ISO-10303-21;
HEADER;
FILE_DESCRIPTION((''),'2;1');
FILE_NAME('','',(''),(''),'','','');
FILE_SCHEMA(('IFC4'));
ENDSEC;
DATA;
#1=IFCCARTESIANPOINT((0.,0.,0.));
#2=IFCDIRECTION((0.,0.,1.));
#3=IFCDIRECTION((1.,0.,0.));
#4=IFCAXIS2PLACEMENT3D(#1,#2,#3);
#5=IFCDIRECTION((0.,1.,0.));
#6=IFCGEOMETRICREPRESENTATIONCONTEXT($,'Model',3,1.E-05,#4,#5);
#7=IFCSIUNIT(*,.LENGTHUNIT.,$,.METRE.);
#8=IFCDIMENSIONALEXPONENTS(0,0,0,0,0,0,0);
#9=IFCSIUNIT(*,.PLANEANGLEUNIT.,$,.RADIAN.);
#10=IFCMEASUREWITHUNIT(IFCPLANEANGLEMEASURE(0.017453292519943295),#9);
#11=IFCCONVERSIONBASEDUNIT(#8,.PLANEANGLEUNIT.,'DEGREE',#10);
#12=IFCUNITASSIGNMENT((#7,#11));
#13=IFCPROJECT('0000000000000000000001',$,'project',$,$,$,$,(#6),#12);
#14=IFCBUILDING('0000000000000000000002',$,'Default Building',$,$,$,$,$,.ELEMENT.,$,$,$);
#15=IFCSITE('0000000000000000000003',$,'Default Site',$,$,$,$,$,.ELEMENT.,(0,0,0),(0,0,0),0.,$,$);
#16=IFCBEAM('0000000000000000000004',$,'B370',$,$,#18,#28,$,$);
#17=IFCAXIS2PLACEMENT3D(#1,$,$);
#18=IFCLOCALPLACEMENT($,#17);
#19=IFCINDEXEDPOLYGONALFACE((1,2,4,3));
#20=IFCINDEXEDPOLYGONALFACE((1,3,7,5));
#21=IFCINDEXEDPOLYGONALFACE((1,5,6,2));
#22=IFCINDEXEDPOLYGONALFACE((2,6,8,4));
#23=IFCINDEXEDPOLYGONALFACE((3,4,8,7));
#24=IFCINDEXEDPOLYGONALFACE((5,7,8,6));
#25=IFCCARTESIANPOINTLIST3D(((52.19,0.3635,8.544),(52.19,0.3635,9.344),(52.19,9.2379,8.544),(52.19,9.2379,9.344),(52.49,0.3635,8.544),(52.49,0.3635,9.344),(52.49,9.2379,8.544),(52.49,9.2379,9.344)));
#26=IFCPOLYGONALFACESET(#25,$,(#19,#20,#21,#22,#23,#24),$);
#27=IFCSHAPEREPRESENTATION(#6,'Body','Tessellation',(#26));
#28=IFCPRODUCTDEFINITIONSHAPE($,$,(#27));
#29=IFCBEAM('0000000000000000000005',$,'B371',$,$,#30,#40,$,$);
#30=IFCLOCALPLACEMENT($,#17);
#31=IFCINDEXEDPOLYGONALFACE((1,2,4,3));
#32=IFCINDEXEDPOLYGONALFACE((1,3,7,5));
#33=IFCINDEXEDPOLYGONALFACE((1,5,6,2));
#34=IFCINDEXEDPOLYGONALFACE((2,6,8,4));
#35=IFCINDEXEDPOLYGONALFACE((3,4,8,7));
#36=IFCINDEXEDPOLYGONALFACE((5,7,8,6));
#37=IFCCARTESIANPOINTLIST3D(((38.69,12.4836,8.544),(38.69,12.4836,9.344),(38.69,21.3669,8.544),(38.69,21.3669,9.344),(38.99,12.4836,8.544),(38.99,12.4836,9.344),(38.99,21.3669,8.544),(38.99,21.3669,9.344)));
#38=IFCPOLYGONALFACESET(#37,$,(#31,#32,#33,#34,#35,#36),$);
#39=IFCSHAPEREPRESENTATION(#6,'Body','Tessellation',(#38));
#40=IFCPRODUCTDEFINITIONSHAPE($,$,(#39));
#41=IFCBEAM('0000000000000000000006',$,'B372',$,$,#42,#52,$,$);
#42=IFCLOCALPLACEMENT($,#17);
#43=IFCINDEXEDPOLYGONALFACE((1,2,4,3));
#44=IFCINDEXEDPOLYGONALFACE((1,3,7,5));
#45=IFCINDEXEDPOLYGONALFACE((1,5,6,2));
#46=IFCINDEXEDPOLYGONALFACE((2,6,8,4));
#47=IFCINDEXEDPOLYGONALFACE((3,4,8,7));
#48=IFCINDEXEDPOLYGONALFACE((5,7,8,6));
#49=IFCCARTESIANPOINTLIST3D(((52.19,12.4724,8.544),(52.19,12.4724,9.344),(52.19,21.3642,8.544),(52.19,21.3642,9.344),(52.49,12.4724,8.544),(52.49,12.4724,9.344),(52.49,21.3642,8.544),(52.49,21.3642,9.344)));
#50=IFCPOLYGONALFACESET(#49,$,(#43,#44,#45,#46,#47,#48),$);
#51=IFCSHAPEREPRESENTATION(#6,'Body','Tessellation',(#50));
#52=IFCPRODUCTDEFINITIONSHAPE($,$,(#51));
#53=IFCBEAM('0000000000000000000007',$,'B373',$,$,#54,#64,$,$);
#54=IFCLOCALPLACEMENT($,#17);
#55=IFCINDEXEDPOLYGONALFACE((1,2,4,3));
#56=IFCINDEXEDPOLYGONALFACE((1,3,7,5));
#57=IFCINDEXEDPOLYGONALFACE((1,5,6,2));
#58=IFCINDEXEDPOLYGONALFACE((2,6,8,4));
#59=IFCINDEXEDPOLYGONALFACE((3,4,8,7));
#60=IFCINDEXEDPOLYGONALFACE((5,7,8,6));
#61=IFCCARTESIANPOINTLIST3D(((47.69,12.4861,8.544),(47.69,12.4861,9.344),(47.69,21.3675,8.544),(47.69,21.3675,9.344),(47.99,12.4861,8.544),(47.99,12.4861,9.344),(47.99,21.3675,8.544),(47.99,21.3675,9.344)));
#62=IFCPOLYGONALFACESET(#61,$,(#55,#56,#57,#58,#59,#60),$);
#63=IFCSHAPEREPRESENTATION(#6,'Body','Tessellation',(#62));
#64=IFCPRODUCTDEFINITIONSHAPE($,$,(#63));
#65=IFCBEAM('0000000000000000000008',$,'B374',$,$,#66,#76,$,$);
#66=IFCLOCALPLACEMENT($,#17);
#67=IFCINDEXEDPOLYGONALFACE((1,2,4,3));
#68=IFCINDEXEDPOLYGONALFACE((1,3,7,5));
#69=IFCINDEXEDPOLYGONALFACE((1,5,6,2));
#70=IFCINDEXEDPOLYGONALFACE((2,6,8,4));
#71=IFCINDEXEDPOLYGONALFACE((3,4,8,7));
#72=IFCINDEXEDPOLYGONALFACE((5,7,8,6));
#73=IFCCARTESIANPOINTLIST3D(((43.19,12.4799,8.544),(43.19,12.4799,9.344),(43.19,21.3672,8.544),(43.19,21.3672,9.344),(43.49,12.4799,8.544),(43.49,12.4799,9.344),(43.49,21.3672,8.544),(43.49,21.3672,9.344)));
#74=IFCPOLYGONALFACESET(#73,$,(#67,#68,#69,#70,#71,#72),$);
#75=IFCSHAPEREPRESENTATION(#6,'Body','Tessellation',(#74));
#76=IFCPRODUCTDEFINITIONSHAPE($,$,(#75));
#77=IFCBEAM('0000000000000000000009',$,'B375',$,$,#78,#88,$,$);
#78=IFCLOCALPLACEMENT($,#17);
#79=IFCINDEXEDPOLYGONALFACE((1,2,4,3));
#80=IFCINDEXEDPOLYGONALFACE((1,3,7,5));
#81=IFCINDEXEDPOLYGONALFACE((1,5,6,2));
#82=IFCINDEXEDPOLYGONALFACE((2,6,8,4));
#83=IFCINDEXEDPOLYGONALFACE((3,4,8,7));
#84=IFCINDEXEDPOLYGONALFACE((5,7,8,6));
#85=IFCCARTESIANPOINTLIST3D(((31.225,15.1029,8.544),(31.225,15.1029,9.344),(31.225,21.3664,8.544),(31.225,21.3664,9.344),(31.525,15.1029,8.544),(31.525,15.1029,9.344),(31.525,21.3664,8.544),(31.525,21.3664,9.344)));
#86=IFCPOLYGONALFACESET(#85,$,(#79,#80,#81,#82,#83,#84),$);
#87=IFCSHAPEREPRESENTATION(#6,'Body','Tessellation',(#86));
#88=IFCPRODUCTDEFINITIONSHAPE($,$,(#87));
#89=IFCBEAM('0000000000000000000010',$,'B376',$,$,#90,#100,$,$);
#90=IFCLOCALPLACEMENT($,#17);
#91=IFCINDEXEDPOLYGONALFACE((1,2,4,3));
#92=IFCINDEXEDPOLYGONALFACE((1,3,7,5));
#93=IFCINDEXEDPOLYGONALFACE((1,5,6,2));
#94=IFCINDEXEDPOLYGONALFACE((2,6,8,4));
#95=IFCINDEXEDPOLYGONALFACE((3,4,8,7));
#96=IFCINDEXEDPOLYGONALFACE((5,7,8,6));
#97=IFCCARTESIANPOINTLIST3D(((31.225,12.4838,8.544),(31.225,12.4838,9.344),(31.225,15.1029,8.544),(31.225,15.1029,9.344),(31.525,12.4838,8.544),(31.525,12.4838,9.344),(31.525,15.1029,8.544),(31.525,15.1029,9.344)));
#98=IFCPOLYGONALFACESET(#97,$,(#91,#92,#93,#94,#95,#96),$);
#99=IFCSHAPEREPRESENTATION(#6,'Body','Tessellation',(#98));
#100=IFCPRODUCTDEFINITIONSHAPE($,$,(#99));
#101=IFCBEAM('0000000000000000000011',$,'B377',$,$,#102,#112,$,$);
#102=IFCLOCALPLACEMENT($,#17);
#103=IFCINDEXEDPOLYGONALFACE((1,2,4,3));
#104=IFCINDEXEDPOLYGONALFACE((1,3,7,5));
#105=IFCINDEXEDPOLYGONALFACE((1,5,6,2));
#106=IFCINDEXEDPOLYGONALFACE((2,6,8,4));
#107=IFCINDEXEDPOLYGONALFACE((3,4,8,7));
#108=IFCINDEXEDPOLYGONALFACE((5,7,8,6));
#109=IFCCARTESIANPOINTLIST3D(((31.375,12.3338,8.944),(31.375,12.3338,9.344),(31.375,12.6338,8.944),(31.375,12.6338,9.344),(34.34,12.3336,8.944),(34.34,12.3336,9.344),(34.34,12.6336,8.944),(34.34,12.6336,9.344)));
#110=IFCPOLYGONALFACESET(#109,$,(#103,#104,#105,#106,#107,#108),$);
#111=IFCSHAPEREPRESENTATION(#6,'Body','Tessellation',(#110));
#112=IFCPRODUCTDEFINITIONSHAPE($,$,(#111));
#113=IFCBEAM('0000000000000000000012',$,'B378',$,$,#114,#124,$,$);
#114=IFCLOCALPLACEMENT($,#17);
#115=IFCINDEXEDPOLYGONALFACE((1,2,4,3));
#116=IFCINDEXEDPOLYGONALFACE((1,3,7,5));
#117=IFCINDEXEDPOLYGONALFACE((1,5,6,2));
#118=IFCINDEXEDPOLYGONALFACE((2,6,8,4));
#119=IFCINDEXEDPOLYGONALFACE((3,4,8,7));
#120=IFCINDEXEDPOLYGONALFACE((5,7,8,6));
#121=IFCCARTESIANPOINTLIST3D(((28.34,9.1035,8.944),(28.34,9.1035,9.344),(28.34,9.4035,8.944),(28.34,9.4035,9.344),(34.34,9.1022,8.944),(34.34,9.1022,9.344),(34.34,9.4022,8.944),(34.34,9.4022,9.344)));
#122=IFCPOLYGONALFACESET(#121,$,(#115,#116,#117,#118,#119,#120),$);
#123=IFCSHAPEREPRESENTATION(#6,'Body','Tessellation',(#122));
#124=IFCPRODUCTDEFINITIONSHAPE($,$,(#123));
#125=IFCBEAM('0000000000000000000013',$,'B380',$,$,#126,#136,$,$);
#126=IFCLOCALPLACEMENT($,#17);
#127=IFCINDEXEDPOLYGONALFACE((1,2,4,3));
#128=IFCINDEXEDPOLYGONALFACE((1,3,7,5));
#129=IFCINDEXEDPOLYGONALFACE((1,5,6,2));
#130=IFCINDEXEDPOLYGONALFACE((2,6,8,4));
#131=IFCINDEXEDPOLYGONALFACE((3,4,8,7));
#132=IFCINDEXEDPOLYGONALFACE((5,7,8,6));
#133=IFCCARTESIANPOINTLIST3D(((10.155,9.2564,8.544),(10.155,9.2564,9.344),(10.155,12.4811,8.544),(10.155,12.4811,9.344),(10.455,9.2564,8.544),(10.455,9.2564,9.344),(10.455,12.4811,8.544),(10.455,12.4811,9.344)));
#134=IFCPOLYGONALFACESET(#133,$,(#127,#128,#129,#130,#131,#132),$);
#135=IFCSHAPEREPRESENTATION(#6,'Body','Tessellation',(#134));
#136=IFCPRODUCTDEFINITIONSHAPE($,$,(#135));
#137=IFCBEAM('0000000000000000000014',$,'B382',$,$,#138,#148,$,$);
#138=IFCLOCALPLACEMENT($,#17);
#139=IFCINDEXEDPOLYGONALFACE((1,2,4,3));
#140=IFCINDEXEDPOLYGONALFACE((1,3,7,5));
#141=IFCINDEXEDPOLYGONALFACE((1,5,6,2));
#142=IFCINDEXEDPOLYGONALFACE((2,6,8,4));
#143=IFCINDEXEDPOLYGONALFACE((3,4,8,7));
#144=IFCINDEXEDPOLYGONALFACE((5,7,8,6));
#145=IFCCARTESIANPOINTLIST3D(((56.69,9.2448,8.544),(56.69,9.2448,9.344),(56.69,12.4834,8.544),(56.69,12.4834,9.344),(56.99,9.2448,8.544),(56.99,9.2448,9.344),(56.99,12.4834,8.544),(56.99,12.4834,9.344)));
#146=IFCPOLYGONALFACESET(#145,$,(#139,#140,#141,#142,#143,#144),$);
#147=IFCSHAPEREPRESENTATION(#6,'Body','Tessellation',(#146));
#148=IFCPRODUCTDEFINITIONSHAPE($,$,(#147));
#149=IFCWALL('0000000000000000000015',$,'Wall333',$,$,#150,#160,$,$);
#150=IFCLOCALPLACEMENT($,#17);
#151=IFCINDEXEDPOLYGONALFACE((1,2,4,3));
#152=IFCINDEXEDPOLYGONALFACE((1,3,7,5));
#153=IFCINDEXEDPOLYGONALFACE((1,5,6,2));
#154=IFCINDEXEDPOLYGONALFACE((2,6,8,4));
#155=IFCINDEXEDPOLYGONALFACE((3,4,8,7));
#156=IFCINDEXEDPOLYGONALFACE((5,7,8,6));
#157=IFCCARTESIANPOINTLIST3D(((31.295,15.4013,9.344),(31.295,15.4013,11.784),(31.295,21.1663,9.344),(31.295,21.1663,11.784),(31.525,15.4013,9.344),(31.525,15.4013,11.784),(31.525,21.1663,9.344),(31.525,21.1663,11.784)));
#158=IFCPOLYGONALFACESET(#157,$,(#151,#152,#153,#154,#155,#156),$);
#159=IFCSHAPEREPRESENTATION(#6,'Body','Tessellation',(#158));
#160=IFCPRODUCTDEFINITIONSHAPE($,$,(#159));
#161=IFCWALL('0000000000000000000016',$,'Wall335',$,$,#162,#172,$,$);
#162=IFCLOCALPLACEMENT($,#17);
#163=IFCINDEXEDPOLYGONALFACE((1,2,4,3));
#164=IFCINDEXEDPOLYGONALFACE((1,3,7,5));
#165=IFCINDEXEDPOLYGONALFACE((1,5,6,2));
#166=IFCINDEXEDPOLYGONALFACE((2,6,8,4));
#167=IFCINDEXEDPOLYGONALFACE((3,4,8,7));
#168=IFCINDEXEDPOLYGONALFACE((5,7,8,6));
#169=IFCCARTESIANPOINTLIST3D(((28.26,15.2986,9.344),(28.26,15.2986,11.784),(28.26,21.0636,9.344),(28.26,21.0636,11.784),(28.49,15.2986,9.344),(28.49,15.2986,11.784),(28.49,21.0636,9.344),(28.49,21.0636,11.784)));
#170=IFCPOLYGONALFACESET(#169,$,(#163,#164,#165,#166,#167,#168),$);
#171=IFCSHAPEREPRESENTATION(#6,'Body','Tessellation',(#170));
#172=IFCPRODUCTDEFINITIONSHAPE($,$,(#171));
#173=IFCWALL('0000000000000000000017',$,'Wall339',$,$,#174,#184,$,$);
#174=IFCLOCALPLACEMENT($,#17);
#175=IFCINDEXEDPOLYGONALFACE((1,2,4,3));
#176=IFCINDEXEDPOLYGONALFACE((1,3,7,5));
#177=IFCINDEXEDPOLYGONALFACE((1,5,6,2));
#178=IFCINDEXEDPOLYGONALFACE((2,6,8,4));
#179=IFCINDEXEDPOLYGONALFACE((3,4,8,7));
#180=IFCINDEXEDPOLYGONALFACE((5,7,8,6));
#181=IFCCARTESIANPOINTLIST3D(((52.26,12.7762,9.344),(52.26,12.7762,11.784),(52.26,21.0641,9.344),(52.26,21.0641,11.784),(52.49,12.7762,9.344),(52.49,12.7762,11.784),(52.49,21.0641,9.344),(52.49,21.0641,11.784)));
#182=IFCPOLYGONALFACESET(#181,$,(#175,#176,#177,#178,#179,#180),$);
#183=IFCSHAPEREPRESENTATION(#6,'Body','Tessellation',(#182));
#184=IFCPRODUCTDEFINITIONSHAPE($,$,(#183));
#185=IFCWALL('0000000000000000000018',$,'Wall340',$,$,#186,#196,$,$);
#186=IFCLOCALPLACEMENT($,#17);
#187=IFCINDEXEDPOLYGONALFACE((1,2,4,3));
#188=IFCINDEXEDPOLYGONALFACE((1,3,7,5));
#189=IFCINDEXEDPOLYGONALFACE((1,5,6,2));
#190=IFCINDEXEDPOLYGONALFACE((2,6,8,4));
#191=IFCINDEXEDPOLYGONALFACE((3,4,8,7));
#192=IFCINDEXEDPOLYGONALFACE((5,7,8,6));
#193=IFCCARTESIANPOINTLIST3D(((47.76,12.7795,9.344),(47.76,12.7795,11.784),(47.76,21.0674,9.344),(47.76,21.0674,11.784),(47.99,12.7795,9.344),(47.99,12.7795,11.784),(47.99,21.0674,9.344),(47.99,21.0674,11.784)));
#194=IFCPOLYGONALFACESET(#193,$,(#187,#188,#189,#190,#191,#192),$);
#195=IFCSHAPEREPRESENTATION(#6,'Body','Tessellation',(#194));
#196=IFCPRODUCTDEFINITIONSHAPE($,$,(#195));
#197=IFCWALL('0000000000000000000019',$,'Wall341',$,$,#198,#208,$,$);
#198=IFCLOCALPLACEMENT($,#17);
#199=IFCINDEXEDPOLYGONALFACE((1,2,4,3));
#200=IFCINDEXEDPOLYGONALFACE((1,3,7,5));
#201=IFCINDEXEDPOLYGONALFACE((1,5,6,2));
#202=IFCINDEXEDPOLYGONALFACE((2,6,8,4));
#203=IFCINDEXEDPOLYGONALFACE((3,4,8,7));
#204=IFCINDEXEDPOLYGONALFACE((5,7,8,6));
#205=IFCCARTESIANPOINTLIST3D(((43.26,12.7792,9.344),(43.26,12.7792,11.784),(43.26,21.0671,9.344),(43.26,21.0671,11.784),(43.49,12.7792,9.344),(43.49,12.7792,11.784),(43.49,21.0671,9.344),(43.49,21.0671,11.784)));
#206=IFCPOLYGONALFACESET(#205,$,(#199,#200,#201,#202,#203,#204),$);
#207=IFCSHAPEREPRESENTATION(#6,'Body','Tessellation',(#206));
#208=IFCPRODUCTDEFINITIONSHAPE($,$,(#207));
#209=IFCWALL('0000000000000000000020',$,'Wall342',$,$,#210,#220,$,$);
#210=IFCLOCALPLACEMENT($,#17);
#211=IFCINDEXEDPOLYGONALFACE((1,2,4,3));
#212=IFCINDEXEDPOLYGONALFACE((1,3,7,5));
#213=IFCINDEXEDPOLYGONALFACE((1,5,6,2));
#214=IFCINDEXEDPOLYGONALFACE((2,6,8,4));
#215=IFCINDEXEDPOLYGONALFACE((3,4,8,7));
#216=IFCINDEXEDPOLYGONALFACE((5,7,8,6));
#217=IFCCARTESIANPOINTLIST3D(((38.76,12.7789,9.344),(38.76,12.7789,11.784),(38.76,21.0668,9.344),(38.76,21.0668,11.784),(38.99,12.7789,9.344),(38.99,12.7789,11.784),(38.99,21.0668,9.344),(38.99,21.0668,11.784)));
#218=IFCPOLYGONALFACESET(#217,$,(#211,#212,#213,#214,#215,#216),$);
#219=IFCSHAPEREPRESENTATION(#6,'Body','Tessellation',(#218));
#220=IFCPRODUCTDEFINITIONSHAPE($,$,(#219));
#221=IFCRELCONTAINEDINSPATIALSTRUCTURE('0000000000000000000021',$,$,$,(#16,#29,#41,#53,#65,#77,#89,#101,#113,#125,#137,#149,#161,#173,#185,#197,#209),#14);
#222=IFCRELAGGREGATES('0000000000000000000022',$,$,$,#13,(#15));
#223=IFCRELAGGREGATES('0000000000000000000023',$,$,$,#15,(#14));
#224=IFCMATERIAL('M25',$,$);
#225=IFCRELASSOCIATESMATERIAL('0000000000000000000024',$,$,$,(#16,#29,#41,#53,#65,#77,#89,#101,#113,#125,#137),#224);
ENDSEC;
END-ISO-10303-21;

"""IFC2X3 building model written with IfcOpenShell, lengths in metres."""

from ifc_helpers import new_model, entity, si_unit, converted_unit, direction, frame, frame_2d, origin_with_axes, place, context, project, spatial, rectangle, extrude, material, element, save


model = new_model("IFC2X3")

# Units and contexts
model_context = context("Model", 3, precision=1e-05, world=origin_with_axes(), true_north=direction((0.0, 1.0, 0.0)))
ifc_project = project(units=[si_unit("LENGTHUNIT", "METRE"), converted_unit("PLANEANGLEUNIT", "DEGREE", entity("IfcPlaneAngleMeasure", 0.017453292519943295), si_unit("PLANEANGLEUNIT", "RADIAN"), dimensions=[0, 0, 0, 0, 0, 0, 0])], contexts=[model_context])

# Site, building
site = spatial("IfcSite", under=ifc_project, Name="Default Site", CompositionType="ELEMENT", RefLatitude=(0, 0, 0), RefLongitude=(0, 0, 0), RefElevation=0.0)
building = spatial("IfcBuilding", under=site, Name="Default Building", CompositionType="ELEMENT")

# Beams
ifc_material = material(Name="M25")
placement = place(None, origin_with_axes())
element("IfcBeam", 1, at=placement, inside=building, material=ifc_material, Name="B370", context=model_context, shape_type="SweptSolid", body=[
    extrude(rectangle(XDim=0.3, YDim=0.8, at=frame_2d((0.0, 0.0), x_axis=(0.0, 1.0, 0.0))), frame((52.34, 0.3635, 8.944), z_axis=(0.0, 1.0, 0.0), x_axis=(0.0, 0.0, -1.0)), (0.0, 0.0, 1.0), 8.8744),
])
element("IfcBeam", 2, at=placement, inside=building, material=ifc_material, Name="B371", context=model_context, shape_type="SweptSolid", body=[
    extrude(rectangle(XDim=0.3, YDim=0.8, at=frame_2d((0.0, 0.0), x_axis=(0.0, 1.0, 0.0))), frame((38.84, 21.3669, 8.944), z_axis=(0.0, -1.0, 0.0), x_axis=(0.0, 0.0, -1.0)), (0.0, 0.0, 1.0), 8.8833),
])
element("IfcBeam", 3, at=placement, inside=building, material=ifc_material, Name="B372", context=model_context, shape_type="SweptSolid", body=[
    extrude(rectangle(XDim=0.3, YDim=0.8, at=frame_2d((0.0, 0.0), x_axis=(0.0, 1.0, 0.0))), frame((52.34, 12.4724, 8.944), z_axis=(0.0, 1.0, 0.0), x_axis=(0.0, 0.0, -1.0)), (0.0, 0.0, 1.0), 8.8918),
])
element("IfcBeam", 4, at=placement, inside=building, material=ifc_material, Name="B373", context=model_context, shape_type="SweptSolid", body=[
    extrude(rectangle(XDim=0.3, YDim=0.8, at=frame_2d((0.0, 0.0), x_axis=(0.0, 1.0, 0.0))), frame((47.84, 12.4861, 8.944), z_axis=(0.0, 1.0, 0.0), x_axis=(0.0, 0.0, -1.0)), (0.0, 0.0, 1.0), 8.8814),
])
element("IfcBeam", 5, at=placement, inside=building, material=ifc_material, Name="B374", context=model_context, shape_type="SweptSolid", body=[
    extrude(rectangle(XDim=0.3, YDim=0.8, at=frame_2d((0.0, 0.0), x_axis=(0.0, 1.0, 0.0))), frame((43.34, 21.3672, 8.944), z_axis=(0.0, -1.0, 0.0), x_axis=(0.0, 0.0, -1.0)), (0.0, 0.0, 1.0), 8.8873),
])
element("IfcBeam", 6, at=placement, inside=building, material=ifc_material, Name="B375", context=model_context, shape_type="SweptSolid", body=[
    extrude(rectangle(XDim=0.3, YDim=0.8, at=frame_2d((0.0, 0.0), x_axis=(0.0, 1.0, 0.0))), frame((31.375, 21.3664, 8.944), z_axis=(0.0, -1.0, 0.0), x_axis=(0.0, 0.0, -1.0)), (0.0, 0.0, 1.0), 6.2635),
])
element("IfcBeam", 7, at=placement, inside=building, material=ifc_material, Name="B376", context=model_context, shape_type="SweptSolid", body=[
    extrude(rectangle(XDim=0.3, YDim=0.8, at=frame_2d((0.0, 0.0), x_axis=(0.0, 1.0, 0.0))), frame((31.375, 15.1029, 8.944), z_axis=(0.0, -1.0, 0.0), x_axis=(0.0, 0.0, -1.0)), (0.0, 0.0, 1.0), 2.6191),
])
element("IfcBeam", 8, at=placement, inside=building, material=ifc_material, Name="B377", context=model_context, shape_type="SweptSolid", body=[
    extrude(rectangle(XDim=0.3, YDim=0.4, at=frame_2d((0.0, 0.0), x_axis=(0.0, 1.0, 0.0))), frame((31.375, 12.4838, 9.144), z_axis=(1.0, -0.000067, 0.0), x_axis=(0.0, 0.0, -1.0)), (0.0, 0.0, 1.0), 2.965),
])
element("IfcBeam", 9, at=placement, inside=building, material=ifc_material, Name="B378", context=model_context, shape_type="SweptSolid", body=[
    extrude(rectangle(XDim=0.3, YDim=0.4, at=frame_2d((0.0, 0.0), x_axis=(0.0, 1.0, 0.0))), frame((28.34, 9.2535, 9.144), z_axis=(1.0, -0.000213, 0.0), x_axis=(0.0, 0.0, -1.0)), (0.0, 0.0, 1.0), 6.0),
])
element("IfcBeam", 10, at=placement, inside=building, material=ifc_material, Name="B380", context=model_context, shape_type="SweptSolid", body=[
    extrude(rectangle(XDim=0.3, YDim=0.8, at=frame_2d((0.0, 0.0), x_axis=(0.0, 1.0, 0.0))), frame((10.305, 12.4811, 8.944), z_axis=(0.0, -1.0, 0.0), x_axis=(0.0, 0.0, -1.0)), (0.0, 0.0, 1.0), 3.2247),
])
element("IfcBeam", 11, at=placement, inside=building, material=ifc_material, Name="B382", context=model_context, shape_type="SweptSolid", body=[
    extrude(rectangle(XDim=0.3, YDim=0.8, at=frame_2d((0.0, 0.0), x_axis=(0.0, 1.0, 0.0))), frame((56.84, 12.4834, 8.944), z_axis=(0.0, -1.0, 0.0), x_axis=(0.0, 0.0, -1.0)), (0.0, 0.0, 1.0), 3.2386),
])

# Walls
element("IfcWall", 12, at=placement, inside=building, Name="Wall333", context=model_context, shape_type="SweptSolid", body=[
    extrude(rectangle(XDim=5.765, YDim=0.23, at=frame_2d((0.0, 0.0), x_axis=(0.0, 1.0, 0.0))), frame((31.41, 18.2838, 9.344), z_axis=(0.0, 0.0, 1.0), x_axis=(1.0, 0.0, 0.0)), (0.0, 0.0, 1.0), 2.44),
])
element("IfcWall", 13, at=placement, inside=building, Name="Wall335", context=model_context, shape_type="SweptSolid", body=[
    extrude(rectangle(XDim=5.765, YDim=0.23, at=frame_2d((0.0, 0.0), x_axis=(0.0, 1.0, 0.0))), frame((28.375, 18.1811, 9.344), z_axis=(0.0, 0.0, 1.0), x_axis=(1.0, 0.0, 0.0)), (0.0, 0.0, 1.0), 2.44),
])
element("IfcWall", 14, at=placement, inside=building, Name="Wall339", context=model_context, shape_type="SweptSolid", body=[
    extrude(rectangle(XDim=8.2879, YDim=0.23, at=frame_2d((0.0, 0.0), x_axis=(0.0, 1.0, 0.0))), frame((52.375, 16.9201, 9.344), z_axis=(0.0, 0.0, 1.0), x_axis=(1.0, 0.0, 0.0)), (0.0, 0.0, 1.0), 2.44),
])
element("IfcWall", 15, at=placement, inside=building, Name="Wall340", context=model_context, shape_type="SweptSolid", body=[
    extrude(rectangle(XDim=8.2879, YDim=0.23, at=frame_2d((0.0, 0.0), x_axis=(0.0, 1.0, 0.0))), frame((47.875, 16.9235, 9.344), z_axis=(0.0, 0.0, 1.0), x_axis=(1.0, 0.0, 0.0)), (0.0, 0.0, 1.0), 2.44),
])
element("IfcWall", 16, at=placement, inside=building, Name="Wall341", context=model_context, shape_type="SweptSolid", body=[
    extrude(rectangle(XDim=8.2879, YDim=0.23, at=frame_2d((0.0, 0.0), x_axis=(0.0, 1.0, 0.0))), frame((43.375, 16.9231, 9.344), z_axis=(0.0, 0.0, 1.0), x_axis=(1.0, 0.0, 0.0)), (0.0, 0.0, 1.0), 2.44),
])
element("IfcWall", 17, at=placement, inside=building, Name="Wall342", context=model_context, shape_type="SweptSolid", body=[
    extrude(rectangle(XDim=8.2879, YDim=0.23, at=frame_2d((0.0, 0.0), x_axis=(0.0, 1.0, 0.0))), frame((38.875, 16.9229, 9.344), z_axis=(0.0, 0.0, 1.0), x_axis=(1.0, 0.0, 0.0)), (0.0, 0.0, 1.0), 2.44),
])

save(model, "model.ifc")
